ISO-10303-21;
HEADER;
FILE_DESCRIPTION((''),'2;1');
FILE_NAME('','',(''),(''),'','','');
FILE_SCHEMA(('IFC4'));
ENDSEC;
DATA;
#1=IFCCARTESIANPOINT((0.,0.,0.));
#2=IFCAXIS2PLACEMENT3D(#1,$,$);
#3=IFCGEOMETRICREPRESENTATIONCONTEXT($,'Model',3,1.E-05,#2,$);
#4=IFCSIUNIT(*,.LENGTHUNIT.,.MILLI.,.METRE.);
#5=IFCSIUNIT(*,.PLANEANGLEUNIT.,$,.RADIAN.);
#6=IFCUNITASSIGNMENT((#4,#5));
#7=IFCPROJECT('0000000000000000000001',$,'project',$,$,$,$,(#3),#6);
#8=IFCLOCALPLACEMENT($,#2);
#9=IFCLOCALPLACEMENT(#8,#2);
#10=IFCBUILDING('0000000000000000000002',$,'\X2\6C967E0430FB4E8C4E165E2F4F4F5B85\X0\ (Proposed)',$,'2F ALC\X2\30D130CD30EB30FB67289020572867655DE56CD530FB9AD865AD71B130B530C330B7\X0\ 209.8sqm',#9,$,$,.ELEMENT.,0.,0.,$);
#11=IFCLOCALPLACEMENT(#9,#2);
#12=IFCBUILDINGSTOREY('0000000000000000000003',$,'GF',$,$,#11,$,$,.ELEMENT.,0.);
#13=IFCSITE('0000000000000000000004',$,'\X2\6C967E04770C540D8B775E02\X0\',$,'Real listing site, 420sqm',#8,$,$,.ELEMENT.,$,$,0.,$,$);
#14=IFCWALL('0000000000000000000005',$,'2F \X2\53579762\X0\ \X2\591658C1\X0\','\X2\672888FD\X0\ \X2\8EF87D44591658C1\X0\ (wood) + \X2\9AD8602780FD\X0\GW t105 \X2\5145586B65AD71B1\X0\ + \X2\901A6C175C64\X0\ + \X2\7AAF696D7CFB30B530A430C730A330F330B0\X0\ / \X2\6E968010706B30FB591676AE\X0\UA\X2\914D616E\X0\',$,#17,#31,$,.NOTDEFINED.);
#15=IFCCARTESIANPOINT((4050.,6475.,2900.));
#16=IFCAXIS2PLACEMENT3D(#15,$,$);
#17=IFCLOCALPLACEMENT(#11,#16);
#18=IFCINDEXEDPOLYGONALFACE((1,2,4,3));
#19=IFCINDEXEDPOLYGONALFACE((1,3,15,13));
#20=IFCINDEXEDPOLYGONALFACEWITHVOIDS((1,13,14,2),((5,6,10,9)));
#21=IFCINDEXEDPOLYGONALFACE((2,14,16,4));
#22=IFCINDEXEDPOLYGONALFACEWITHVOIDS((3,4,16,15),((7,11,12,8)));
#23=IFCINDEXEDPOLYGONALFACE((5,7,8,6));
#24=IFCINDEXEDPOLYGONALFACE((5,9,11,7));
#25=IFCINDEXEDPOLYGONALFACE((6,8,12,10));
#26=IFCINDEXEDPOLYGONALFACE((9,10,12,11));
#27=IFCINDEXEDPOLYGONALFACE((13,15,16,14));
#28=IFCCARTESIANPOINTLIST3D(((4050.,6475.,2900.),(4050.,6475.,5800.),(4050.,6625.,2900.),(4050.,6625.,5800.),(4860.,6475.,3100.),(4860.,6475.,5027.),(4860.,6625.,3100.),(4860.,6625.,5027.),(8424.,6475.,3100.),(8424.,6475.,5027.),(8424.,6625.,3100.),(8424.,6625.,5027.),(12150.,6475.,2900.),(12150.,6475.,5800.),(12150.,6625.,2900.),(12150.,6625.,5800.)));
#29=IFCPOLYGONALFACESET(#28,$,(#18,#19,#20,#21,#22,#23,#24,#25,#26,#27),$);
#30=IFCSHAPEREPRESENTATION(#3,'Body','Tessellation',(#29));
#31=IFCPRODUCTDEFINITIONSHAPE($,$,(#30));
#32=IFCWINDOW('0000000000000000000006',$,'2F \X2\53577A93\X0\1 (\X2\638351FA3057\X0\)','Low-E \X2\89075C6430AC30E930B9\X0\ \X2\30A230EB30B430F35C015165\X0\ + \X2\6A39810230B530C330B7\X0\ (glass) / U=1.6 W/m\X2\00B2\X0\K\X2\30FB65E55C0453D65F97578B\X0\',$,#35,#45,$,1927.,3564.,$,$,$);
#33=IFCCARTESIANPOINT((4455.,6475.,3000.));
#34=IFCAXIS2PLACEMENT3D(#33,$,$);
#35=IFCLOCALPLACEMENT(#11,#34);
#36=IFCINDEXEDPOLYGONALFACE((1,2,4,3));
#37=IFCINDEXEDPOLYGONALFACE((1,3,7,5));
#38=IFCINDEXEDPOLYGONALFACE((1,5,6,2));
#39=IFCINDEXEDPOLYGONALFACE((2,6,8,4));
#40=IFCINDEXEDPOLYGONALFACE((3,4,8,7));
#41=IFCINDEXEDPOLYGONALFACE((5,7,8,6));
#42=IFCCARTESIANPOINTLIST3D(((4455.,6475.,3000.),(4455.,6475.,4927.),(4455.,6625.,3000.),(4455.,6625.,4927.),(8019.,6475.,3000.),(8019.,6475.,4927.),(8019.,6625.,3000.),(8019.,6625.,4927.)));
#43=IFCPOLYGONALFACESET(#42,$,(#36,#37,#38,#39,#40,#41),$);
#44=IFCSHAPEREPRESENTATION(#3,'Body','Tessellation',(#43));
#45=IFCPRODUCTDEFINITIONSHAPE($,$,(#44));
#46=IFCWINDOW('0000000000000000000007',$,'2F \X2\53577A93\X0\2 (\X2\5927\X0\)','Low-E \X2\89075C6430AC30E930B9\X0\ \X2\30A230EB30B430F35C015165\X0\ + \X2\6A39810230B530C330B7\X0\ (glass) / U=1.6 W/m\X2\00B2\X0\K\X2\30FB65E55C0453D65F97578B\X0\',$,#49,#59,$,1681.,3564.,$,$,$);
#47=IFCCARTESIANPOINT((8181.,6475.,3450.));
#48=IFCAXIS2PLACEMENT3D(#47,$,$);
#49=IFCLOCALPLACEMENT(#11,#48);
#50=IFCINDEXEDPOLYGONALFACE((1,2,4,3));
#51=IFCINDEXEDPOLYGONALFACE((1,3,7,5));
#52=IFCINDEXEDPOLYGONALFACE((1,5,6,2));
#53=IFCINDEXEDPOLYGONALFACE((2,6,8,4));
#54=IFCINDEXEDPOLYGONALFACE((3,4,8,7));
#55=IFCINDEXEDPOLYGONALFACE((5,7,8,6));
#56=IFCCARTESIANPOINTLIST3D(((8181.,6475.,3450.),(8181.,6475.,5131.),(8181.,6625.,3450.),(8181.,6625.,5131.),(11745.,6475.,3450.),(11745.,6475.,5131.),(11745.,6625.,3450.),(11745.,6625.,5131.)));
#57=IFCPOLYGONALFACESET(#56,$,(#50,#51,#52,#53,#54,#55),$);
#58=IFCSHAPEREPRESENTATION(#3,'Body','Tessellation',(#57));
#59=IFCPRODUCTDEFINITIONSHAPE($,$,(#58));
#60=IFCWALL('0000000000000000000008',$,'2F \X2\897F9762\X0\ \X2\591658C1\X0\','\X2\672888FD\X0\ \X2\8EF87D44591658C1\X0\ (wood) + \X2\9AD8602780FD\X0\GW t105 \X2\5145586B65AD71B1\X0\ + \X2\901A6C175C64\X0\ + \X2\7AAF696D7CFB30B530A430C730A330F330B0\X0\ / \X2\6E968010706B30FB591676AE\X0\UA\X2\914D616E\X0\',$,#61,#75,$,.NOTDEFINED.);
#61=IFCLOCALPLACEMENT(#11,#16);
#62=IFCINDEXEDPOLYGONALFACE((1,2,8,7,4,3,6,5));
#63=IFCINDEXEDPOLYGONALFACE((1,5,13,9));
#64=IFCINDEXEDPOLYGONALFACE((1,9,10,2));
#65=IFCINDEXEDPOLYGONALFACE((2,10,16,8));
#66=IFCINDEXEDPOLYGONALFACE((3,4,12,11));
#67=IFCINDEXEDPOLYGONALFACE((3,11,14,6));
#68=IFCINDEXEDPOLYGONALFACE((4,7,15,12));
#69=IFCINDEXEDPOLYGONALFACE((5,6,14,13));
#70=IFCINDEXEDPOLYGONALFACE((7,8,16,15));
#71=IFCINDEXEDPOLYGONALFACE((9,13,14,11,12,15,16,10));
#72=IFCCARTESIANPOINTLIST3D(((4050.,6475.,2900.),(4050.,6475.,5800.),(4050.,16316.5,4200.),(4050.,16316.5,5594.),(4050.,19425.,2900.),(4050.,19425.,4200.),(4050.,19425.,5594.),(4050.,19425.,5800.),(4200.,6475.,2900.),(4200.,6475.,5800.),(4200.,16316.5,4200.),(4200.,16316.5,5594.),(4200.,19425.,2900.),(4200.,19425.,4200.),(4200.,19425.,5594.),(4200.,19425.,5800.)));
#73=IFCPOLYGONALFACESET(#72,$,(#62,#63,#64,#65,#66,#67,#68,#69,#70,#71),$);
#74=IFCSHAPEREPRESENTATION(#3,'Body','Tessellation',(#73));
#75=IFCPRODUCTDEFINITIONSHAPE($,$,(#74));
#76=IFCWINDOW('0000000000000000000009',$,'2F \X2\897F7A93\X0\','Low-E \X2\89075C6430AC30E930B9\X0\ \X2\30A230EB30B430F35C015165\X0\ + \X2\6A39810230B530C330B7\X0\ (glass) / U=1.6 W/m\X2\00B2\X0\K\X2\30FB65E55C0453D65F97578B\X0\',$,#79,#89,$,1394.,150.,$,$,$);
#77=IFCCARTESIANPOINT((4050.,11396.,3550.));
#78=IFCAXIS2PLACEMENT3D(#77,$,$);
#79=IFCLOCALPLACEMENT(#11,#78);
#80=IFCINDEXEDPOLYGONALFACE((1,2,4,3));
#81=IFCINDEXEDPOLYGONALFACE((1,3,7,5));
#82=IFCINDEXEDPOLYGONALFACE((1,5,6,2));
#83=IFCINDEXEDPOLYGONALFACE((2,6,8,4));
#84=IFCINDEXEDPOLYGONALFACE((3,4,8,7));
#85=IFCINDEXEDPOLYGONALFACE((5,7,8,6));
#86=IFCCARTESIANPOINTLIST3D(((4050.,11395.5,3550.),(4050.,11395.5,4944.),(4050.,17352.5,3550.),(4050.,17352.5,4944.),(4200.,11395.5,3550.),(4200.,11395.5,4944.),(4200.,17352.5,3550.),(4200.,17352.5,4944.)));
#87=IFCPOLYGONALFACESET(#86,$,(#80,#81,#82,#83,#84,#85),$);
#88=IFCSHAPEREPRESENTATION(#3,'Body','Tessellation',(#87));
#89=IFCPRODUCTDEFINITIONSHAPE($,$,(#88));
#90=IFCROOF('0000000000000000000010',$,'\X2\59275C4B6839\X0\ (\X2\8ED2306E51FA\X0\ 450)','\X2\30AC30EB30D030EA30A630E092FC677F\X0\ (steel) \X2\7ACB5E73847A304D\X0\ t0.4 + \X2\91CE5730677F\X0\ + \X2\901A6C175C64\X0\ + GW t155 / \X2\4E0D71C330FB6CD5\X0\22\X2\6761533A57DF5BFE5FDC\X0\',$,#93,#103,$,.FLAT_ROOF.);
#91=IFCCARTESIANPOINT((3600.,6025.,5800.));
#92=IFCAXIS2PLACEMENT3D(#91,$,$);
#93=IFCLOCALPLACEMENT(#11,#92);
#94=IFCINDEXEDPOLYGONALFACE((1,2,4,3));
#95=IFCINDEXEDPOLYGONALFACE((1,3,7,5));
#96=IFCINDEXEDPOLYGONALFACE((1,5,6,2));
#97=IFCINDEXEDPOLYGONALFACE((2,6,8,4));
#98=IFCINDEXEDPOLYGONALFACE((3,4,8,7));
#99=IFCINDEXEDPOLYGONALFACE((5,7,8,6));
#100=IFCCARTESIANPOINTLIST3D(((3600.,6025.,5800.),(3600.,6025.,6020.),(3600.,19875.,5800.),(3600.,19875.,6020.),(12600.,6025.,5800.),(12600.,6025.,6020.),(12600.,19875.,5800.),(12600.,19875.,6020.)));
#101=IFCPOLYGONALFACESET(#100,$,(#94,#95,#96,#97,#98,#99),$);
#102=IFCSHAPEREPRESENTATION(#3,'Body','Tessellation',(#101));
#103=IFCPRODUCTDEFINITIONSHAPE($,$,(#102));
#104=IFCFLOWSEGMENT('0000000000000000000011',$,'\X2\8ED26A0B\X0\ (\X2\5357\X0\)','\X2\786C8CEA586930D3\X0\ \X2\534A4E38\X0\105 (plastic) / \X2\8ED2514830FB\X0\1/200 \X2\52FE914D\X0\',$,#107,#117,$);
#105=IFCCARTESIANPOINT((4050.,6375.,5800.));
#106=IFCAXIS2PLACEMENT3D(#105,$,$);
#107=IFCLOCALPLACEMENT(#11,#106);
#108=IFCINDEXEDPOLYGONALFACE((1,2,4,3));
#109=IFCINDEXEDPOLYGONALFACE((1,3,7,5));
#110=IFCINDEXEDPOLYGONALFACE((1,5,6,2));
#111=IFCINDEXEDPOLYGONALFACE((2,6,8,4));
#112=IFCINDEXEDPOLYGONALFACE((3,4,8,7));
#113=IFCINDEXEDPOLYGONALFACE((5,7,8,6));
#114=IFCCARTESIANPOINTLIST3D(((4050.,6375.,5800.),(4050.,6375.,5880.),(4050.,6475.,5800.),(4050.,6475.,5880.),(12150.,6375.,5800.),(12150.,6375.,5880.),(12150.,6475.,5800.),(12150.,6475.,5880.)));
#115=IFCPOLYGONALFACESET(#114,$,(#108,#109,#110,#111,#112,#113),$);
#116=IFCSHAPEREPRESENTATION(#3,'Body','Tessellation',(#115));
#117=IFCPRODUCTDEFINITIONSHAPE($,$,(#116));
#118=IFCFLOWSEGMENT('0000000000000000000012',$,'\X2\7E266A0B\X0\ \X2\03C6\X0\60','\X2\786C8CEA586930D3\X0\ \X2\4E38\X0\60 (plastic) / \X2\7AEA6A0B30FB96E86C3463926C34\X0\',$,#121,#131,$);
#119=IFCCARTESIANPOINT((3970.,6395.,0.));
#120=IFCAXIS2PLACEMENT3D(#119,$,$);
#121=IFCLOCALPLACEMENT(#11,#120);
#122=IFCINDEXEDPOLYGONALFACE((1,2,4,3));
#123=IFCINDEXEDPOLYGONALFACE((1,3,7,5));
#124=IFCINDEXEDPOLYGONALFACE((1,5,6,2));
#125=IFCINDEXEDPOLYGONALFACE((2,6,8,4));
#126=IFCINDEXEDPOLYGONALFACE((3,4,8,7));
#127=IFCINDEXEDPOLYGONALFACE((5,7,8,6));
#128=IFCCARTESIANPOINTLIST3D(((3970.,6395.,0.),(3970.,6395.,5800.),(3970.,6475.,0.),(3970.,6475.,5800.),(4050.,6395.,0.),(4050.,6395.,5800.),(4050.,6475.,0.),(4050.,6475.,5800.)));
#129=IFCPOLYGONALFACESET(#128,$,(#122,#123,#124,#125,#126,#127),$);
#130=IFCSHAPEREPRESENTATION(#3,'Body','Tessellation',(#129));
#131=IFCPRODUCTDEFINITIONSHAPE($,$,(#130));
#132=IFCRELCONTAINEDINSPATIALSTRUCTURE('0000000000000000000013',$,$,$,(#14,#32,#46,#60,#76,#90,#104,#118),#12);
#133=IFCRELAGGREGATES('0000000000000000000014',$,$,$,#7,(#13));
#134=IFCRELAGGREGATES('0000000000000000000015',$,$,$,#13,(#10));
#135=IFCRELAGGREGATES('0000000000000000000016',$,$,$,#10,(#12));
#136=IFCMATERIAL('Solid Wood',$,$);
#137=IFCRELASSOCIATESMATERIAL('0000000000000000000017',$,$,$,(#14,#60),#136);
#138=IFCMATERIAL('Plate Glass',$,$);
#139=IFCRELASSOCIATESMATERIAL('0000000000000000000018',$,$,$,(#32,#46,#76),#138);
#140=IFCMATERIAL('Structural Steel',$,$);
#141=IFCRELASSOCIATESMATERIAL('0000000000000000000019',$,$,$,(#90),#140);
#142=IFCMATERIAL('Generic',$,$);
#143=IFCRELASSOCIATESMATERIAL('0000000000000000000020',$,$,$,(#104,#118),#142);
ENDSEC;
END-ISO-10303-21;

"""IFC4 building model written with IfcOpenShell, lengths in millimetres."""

from ifc_helpers import new_model, si_unit, frame, frame_2d, origin, place, context, project, spatial, rectangle, extrude, material, element, fill, save


model = new_model("IFC4")

# Units and contexts
model_context = context("Model", 3, precision=1e-05, world=origin())
ifc_project = project(units=[si_unit("LENGTHUNIT", "METRE", prefix="MILLI"), si_unit("PLANEANGLEUNIT", "RADIAN")], contexts=[model_context])

# Site, building, storey
site_placement = place(None, origin())
site = spatial("IfcSite", under=ifc_project, at=site_placement, Name="沖縄県名護市", ObjectType="Real listing site, 420sqm", CompositionType="ELEMENT", RefElevation=0.0)
building_placement = place(site_placement, origin())
building = spatial("IfcBuilding", under=site, at=building_placement, Name="沖縄・二世帯住宅 (Proposed)", ObjectType="2F ALCパネル・木造在来工法・高断熱サッシ 209.8sqm", CompositionType="ELEMENT", ElevationOfRefHeight=0.0, ElevationOfTerrain=0.0)
storey_placement = place(building_placement, origin())
storey = spatial("IfcBuildingStorey", under=building, at=storey_placement, Name="GF", CompositionType="ELEMENT", Elevation=0.0)

# Shared definitions
ifc_material_1 = material(Name="Solid Wood")

# Shared definitions
ifc_material_2 = material(Name="Plate Glass")

# Wall, openings, windows
wall_1_placement = place(storey_placement, frame((4050.0, 6475.0, 2900.0)))
wall_1 = element("IfcWall", 1, at=wall_1_placement, inside=storey, material=ifc_material_1, Name="2F 南面 外壁", Description="木製 軸組外壁 (wood) + 高性能GW t105 充填断熱 + 通気層 + 窯業系サイディング / 準耐火・外皮UA配慮", PredefinedType="NOTDEFINED", context=model_context, shape_type="SweptSolid", body=[
    extrude(rectangle(XDim=8100.0, YDim=150.0, at=frame_2d((4050.0, 75.0))), frame((4050.0, 6475.0, 2900.0)), (0.0, 0.0, 1.0), 2900.0),
])
opening_1_placement = place(storey_placement, frame((4455.0, 6475.0, 3000.0)))
opening_1 = element("IfcOpeningElement", 2, at=opening_1_placement, cuts=wall_1, PredefinedType="NOTDEFINED", context=model_context, shape_type="SweptSolid", body=[
    extrude(rectangle(XDim=3564.0, YDim=150.0, at=frame_2d((1782.0, 75.0))), frame((4455.0, 6475.0, 3000.0)), (0.0, 0.0, 1.0), 1927.0),
])
opening_2_placement = place(storey_placement, frame((8181.0, 6475.0, 3450.0)))
opening_2 = element("IfcOpeningElement", 3, at=opening_2_placement, cuts=wall_1, PredefinedType="NOTDEFINED", context=model_context, shape_type="SweptSolid", body=[
    extrude(rectangle(XDim=3564.0, YDim=150.0, at=frame_2d((1782.0, 75.0))), frame((8181.0, 6475.0, 3450.0)), (0.0, 0.0, 1.0), 1681.0),
])
window_1_placement = place(storey_placement, frame((4455.0, 6475.0, 3000.0)))
window_1 = element("IfcWindow", 4, at=window_1_placement, inside=storey, material=ifc_material_2, Name="2F 南窓1 (掃出し)", Description="Low-E 複層ガラス アルゴン封入 + 樹脂サッシ (glass) / U=1.6 W/m²K・日射取得型", OverallHeight=1927.0, OverallWidth=3564.0, context=model_context, shape_type="SweptSolid", body=[
    extrude(rectangle(XDim=3564.0, YDim=150.0, at=frame_2d((1782.0, 75.0))), frame((4455.0, 6475.0, 3000.0)), (0.0, 0.0, 1.0), 1927.0),
])
fill(opening_1, window_1)
window_2_placement = place(storey_placement, frame((8181.0, 6475.0, 3450.0)))
window_2 = element("IfcWindow", 5, at=window_2_placement, inside=storey, material=ifc_material_2, Name="2F 南窓2 (大)", Description="Low-E 複層ガラス アルゴン封入 + 樹脂サッシ (glass) / U=1.6 W/m²K・日射取得型", OverallHeight=1681.0, OverallWidth=3564.0, context=model_context, shape_type="SweptSolid", body=[
    extrude(rectangle(XDim=3564.0, YDim=150.0, at=frame_2d((1782.0, 75.0))), frame((8181.0, 6475.0, 3450.0)), (0.0, 0.0, 1.0), 1681.0),
])
fill(opening_2, window_2)

# Wall, opening, window
wall_2_placement = place(storey_placement, frame((4050.0, 6475.0, 2900.0)))
wall_2 = element("IfcWall", 6, at=wall_2_placement, inside=storey, material=ifc_material_1, Name="2F 西面 外壁", Description="木製 軸組外壁 (wood) + 高性能GW t105 充填断熱 + 通気層 + 窯業系サイディング / 準耐火・外皮UA配慮", PredefinedType="NOTDEFINED", context=model_context, shape_type="SweptSolid", body=[
    extrude(rectangle(XDim=150.0, YDim=12950.0, at=frame_2d((75.0, 6475.0))), frame((4050.0, 6475.0, 2900.0)), (0.0, 0.0, 1.0), 2900.0),
])
opening_3_placement = place(storey_placement, frame((4050.0, 11396.0, 3550.0)))
opening_3 = element("IfcOpeningElement", 7, at=opening_3_placement, cuts=wall_2, PredefinedType="NOTDEFINED", context=model_context, shape_type="SweptSolid", body=[
    extrude(rectangle(XDim=150.0, YDim=5957.0, at=frame_2d((75.0, 2978.0))), frame((4050.0, 11396.0, 3550.0)), (0.0, 0.0, 1.0), 1394.0),
])
window_3_placement = place(storey_placement, frame((4050.0, 11396.0, 3550.0)))
window_3 = element("IfcWindow", 8, at=window_3_placement, inside=storey, material=ifc_material_2, Name="2F 西窓", Description="Low-E 複層ガラス アルゴン封入 + 樹脂サッシ (glass) / U=1.6 W/m²K・日射取得型", OverallHeight=1394.0, OverallWidth=150.0, context=model_context, shape_type="SweptSolid", body=[
    extrude(rectangle(XDim=150.0, YDim=5957.0, at=frame_2d((75.0, 2978.0))), frame((4050.0, 11396.0, 3550.0)), (0.0, 0.0, 1.0), 1394.0),
])
fill(opening_3, window_3)

# Roof
ifc_material_3 = material(Name="Structural Steel")
roof_placement = place(storey_placement, frame((3600.0, 6025.0, 5800.0)))
element("IfcRoof", 9, at=roof_placement, inside=storey, material=ifc_material_3, Name="大屋根 (軒の出 450)", Description="ガルバリウム鋼板 (steel) 立平葺き t0.4 + 野地板 + 通気層 + GW t155 / 不燃・法22条区域対応", PredefinedType="FLAT_ROOF", context=model_context, shape_type="SweptSolid", body=[
    extrude(rectangle(XDim=9000.0, YDim=13850.0, at=frame_2d((4500.0, 6925.0))), frame((3600.0, 6025.0, 5800.0)), (0.0, 0.0, 1.0), 220.0),
])

# Flow segments
ifc_material_4 = material(Name="Generic")
flow_segment_1_placement = place(storey_placement, frame((4050.0, 6375.0, 5800.0)))
element("IfcFlowSegment", 10, at=flow_segment_1_placement, inside=storey, material=ifc_material_4, Name="軒樋 (南)", Description="硬質塩ビ 半丸105 (plastic) / 軒先・1/200 勾配", context=model_context, shape_type="SweptSolid", body=[
    extrude(rectangle(XDim=8100.0, YDim=100.0, at=frame_2d((4050.0, 50.0))), frame((4050.0, 6375.0, 5800.0)), (0.0, 0.0, 1.0), 80.0),
])
flow_segment_2_placement = place(storey_placement, frame((3970.0, 6395.0, 0.0)))
element("IfcFlowSegment", 11, at=flow_segment_2_placement, inside=storey, material=ifc_material_4, Name="縦樋 φ60", Description="硬質塩ビ 丸60 (plastic) / 竪樋・雨水排水", context=model_context, shape_type="SweptSolid", body=[
    extrude(rectangle(XDim=80.0, YDim=80.0, at=frame_2d((40.0, 40.0))), frame((3970.0, 6395.0, 0.0)), (0.0, 0.0, 1.0), 5800.0),
])

save(model, "model.ifc")
